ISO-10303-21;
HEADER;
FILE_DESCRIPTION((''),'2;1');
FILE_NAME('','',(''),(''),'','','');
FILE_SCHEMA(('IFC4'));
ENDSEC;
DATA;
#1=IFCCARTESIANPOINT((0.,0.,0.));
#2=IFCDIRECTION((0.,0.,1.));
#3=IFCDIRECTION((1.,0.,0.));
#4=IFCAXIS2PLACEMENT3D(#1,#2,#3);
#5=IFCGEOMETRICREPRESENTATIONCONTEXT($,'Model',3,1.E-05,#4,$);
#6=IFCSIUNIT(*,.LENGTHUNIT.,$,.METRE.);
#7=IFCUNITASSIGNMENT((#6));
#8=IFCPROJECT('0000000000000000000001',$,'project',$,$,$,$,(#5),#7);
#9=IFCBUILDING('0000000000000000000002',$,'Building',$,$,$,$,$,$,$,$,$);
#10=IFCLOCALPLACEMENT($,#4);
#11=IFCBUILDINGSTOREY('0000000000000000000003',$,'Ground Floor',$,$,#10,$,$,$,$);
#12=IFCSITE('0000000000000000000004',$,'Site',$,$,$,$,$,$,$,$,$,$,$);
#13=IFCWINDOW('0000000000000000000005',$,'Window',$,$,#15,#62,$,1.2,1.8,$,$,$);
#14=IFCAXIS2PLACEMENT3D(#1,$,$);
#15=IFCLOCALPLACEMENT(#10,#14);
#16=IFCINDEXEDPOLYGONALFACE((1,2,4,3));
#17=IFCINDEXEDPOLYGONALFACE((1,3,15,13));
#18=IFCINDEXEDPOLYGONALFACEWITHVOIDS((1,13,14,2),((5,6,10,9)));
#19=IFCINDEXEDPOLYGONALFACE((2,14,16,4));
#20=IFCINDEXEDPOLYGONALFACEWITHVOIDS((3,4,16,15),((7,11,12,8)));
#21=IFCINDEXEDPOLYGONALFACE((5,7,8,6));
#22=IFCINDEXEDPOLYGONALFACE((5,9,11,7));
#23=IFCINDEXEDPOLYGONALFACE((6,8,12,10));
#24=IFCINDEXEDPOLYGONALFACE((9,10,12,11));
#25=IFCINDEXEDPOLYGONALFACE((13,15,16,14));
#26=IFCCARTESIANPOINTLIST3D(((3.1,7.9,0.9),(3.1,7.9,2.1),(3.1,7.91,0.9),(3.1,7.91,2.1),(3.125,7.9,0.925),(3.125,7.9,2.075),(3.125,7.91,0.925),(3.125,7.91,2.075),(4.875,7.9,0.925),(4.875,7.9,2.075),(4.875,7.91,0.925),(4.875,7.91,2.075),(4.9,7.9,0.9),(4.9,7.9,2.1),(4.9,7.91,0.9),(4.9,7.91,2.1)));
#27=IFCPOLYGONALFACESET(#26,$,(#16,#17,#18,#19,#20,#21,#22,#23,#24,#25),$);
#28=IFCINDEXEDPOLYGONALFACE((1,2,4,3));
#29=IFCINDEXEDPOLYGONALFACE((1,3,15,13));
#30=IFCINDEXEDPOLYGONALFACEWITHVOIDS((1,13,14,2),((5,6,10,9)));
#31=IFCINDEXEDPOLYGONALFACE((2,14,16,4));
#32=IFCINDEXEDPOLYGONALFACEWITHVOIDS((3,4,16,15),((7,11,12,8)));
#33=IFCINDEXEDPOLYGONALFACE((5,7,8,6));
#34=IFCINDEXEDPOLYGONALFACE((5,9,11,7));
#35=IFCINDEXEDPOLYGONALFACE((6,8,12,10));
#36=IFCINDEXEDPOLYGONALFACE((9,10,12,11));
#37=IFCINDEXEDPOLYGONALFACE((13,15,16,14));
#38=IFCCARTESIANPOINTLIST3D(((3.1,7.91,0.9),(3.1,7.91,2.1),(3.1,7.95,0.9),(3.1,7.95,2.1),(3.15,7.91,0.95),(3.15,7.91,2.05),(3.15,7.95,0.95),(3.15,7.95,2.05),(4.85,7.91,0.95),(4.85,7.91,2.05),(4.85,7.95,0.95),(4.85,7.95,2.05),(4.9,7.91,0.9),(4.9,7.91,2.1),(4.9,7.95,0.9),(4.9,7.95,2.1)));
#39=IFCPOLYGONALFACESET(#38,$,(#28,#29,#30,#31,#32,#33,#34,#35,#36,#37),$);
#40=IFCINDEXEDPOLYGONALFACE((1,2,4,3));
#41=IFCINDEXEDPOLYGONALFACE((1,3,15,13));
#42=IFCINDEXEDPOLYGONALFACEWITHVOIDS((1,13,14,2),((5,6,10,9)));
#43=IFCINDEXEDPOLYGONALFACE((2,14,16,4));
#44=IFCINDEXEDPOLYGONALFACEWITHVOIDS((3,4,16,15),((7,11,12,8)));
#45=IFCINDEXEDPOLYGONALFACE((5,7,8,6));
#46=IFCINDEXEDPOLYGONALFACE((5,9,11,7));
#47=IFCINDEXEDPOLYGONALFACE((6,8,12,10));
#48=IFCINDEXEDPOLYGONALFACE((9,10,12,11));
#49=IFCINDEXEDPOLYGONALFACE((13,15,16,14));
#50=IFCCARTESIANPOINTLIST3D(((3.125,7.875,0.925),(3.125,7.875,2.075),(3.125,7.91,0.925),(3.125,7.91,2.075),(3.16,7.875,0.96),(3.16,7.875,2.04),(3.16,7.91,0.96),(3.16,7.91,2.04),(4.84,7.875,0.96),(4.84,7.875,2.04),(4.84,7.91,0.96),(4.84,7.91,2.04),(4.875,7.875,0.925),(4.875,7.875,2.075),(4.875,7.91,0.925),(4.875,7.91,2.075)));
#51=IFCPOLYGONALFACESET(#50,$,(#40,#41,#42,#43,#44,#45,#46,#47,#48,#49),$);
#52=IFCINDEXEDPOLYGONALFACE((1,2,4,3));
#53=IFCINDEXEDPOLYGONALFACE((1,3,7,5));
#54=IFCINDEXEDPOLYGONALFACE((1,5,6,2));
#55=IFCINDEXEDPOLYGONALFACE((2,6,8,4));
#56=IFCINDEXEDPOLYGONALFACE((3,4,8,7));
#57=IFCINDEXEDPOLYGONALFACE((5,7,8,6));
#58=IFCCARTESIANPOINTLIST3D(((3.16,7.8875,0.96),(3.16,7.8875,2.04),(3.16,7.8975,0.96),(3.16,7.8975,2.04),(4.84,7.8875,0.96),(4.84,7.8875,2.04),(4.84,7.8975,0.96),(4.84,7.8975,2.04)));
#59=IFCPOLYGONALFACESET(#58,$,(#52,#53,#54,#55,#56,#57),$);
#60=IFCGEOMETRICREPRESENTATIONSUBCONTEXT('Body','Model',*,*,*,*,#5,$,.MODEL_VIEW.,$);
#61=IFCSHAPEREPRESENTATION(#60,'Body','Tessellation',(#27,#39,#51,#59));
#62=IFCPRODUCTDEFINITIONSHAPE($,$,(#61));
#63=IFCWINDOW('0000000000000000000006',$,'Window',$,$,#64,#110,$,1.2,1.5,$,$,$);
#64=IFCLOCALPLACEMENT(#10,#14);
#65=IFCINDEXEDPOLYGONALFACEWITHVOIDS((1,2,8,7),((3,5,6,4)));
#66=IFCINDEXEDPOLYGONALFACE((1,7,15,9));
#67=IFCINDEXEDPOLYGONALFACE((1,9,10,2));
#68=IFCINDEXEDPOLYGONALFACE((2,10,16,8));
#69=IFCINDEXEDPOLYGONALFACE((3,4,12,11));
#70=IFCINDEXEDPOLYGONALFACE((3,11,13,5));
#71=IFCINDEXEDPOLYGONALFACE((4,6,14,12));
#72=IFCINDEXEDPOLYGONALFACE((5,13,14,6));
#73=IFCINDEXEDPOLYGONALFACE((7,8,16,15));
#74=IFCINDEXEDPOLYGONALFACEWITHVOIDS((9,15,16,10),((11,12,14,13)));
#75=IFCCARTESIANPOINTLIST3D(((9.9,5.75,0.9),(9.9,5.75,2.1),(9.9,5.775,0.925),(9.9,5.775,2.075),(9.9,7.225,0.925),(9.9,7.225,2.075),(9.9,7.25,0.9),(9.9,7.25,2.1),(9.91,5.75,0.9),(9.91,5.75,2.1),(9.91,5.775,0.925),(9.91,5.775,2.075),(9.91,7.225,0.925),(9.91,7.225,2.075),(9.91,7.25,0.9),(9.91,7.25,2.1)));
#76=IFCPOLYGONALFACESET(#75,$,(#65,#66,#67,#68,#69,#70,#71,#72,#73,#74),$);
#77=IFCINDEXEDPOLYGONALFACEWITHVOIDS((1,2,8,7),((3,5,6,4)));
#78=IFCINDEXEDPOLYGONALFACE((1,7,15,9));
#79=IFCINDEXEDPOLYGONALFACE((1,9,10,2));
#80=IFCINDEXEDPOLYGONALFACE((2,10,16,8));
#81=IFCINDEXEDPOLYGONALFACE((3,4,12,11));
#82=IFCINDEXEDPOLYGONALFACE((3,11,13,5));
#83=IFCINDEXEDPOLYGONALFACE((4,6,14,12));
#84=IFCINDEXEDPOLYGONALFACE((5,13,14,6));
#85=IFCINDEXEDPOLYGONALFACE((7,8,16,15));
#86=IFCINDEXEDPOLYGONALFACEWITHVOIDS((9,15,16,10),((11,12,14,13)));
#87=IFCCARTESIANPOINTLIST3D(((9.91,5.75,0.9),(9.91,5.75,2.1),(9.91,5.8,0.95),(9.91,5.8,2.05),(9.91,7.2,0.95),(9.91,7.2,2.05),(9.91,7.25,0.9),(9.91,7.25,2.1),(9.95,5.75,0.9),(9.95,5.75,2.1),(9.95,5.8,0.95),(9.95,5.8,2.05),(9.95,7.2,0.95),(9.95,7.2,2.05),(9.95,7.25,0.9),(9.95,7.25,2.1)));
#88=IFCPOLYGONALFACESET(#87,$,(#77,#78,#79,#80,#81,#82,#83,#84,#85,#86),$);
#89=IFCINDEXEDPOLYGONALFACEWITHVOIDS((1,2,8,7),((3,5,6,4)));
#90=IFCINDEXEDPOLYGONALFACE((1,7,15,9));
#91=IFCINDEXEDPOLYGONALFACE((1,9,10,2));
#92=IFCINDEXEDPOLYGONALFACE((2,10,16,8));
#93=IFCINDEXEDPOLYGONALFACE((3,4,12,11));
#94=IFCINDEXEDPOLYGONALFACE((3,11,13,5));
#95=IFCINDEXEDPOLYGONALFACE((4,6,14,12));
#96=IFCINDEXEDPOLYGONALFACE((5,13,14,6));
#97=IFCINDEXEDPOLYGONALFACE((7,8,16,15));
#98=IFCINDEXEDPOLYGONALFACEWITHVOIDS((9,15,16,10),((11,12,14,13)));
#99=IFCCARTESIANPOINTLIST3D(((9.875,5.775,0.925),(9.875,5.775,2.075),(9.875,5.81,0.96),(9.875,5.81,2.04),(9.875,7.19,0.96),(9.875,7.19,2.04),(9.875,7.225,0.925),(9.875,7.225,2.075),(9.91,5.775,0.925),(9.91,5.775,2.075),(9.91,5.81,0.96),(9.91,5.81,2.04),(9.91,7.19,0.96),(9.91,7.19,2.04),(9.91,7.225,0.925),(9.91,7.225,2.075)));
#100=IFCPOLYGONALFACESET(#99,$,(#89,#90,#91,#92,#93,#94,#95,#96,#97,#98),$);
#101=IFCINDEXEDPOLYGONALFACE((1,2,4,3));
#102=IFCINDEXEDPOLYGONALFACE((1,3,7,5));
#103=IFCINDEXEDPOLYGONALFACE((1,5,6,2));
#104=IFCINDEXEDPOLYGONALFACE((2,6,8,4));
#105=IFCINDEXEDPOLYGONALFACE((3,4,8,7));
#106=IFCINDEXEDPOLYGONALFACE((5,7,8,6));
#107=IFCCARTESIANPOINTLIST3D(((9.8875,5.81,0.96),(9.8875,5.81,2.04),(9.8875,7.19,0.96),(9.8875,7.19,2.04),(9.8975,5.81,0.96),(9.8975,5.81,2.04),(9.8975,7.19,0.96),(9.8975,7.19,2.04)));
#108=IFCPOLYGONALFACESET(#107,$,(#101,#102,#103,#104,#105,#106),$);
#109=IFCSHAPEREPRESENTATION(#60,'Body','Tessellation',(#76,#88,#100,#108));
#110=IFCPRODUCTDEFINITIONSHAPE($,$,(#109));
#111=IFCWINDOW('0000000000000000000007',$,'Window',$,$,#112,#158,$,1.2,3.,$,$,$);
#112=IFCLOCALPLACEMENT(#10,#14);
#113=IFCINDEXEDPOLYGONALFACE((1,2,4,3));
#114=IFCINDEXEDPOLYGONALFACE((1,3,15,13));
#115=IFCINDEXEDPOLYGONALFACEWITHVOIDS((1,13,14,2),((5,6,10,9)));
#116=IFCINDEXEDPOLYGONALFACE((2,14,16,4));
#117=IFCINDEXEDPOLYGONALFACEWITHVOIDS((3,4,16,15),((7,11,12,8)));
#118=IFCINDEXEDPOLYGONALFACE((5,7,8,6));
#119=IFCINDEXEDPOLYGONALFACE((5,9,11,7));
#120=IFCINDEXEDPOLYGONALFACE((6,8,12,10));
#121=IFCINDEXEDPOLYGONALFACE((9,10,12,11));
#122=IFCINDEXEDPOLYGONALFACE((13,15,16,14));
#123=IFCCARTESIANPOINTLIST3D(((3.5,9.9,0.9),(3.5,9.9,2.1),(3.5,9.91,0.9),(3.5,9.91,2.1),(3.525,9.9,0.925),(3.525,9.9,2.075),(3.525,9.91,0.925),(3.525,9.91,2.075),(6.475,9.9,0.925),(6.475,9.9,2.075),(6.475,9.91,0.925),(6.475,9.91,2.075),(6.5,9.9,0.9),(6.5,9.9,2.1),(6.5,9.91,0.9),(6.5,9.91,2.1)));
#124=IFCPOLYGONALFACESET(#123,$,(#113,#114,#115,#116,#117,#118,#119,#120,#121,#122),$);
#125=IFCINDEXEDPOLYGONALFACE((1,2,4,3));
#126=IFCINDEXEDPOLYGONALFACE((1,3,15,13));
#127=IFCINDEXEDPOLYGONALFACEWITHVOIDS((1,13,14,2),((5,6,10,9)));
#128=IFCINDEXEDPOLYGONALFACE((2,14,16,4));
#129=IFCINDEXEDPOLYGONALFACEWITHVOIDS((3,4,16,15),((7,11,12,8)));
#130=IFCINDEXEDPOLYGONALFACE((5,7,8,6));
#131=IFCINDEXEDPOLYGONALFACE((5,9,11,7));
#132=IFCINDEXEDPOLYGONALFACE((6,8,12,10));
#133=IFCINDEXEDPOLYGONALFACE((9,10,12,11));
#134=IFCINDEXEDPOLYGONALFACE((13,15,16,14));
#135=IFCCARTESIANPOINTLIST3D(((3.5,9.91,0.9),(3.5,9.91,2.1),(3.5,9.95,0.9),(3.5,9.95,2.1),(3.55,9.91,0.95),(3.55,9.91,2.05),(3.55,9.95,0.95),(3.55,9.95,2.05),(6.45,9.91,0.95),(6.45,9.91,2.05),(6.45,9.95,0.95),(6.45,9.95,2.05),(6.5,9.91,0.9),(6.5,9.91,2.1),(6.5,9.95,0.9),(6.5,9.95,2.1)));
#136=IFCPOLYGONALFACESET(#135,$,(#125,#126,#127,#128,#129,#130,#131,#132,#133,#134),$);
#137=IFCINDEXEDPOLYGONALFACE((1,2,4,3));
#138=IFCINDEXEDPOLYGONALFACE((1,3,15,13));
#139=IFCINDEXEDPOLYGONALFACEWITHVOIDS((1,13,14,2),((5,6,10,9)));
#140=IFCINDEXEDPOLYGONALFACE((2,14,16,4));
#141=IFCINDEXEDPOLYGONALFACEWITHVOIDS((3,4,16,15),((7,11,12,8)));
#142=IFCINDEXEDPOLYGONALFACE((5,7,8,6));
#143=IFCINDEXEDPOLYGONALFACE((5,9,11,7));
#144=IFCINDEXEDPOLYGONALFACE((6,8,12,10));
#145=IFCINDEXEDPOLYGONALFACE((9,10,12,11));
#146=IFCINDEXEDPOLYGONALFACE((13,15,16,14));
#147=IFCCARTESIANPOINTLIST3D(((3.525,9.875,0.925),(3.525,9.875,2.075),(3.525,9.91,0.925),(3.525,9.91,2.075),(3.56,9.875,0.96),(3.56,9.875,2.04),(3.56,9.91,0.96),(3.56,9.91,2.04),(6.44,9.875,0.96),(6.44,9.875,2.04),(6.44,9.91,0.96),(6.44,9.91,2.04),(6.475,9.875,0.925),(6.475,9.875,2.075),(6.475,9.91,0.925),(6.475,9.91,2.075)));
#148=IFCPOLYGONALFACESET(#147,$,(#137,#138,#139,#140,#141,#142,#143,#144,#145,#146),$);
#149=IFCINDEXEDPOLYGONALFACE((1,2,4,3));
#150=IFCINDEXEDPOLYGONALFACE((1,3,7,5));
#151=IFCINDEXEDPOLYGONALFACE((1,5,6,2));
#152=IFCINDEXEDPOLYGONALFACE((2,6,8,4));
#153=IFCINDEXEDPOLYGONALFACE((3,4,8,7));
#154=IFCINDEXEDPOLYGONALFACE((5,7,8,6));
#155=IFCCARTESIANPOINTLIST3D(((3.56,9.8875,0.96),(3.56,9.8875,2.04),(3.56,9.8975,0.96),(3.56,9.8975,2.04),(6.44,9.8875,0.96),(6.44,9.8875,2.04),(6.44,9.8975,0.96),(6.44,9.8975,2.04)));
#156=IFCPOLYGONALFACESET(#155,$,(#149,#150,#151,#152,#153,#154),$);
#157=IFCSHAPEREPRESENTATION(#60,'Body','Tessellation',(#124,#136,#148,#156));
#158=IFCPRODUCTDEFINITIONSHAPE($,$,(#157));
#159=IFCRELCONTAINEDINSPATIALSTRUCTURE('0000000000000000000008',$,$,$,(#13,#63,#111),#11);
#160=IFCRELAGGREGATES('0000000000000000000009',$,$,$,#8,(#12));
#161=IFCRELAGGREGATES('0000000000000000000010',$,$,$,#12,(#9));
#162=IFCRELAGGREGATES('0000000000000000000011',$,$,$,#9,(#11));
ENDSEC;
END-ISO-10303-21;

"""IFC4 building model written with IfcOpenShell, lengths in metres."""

from ifc_helpers import new_model, si_unit, frame, origin_with_axes, place, context, subcontext, project, spatial, line, indexed_curve, outline, extrude, element, save


model = new_model("IFC4")

# Units and contexts
model_context = context("Model", 3, precision=1e-05, world=origin_with_axes())
body_context = subcontext(model_context, "Body", "Model", "MODEL_VIEW")
ifc_project = project(units=[si_unit("LENGTHUNIT", "METRE")], contexts=[model_context])

# Site, building, storey
site = spatial("IfcSite", under=ifc_project, Name="Site")
building = spatial("IfcBuilding", under=site, Name="Building")
storey_placement = place(None, origin_with_axes())
storey = spatial("IfcBuildingStorey", under=building, at=storey_placement, Name="Ground Floor")

# Windows
window_1_placement = place(storey_placement, frame((4.9, 8.0, 0.9), z_axis=(0.0, 0.0, 1.0), x_axis=(-1.0, 0.0, 0.0)))
element("IfcWindow", 1, at=window_1_placement, inside=storey, Name="Window", OverallHeight=1.2, OverallWidth=1.8, context=body_context, shape_type="SweptSolid", body=[
    extrude(outline(indexed_curve([(0.0, 0.0), (1.8, 0.0), (1.8, 1.2), (0.0, 1.2)], segments=[line(1, 2, 3, 4, 1)]), holes=[indexed_curve([(0.025, 0.025), (1.775, 0.025), (1.775, 1.175), (0.025, 1.175)], segments=[line(1, 2, 3, 4, 1)])]), frame((0.0, 0.09, 0.0), z_axis=(0.0, -1.0, 0.0), x_axis=(1.0, 0.0, 0.0)), (0.0, 0.0, -1.0), 0.01),
    extrude(outline(indexed_curve([(0.0, 0.0), (1.8, 0.0), (1.8, 1.2), (0.0, 1.2)], segments=[line(1, 2, 3, 4, 1)]), holes=[indexed_curve([(0.05, 0.05), (1.75, 0.05), (1.75, 1.15), (0.05, 1.15)], segments=[line(1, 2, 3, 4, 1)])]), frame((0.0, 0.05, 0.0), z_axis=(0.0, -1.0, 0.0), x_axis=(1.0, 0.0, 0.0)), (0.0, 0.0, -1.0), 0.04),
    extrude(outline(indexed_curve([(0.0, 0.0), (1.75, 0.0), (1.75, 1.15), (0.0, 1.15)], segments=[line(1, 2, 3, 4, 1)]), holes=[indexed_curve([(0.035, 0.035), (1.715, 0.035), (1.715, 1.115), (0.035, 1.115)], segments=[line(1, 2, 3, 4, 1)])]), frame((0.025, 0.09, 0.025), z_axis=(0.0, -1.0, 0.0), x_axis=(1.0, 0.0, 0.0)), (0.0, 0.0, -1.0), 0.035),
    extrude(outline(indexed_curve([(0.035, 0.035), (1.715, 0.035), (1.715, 1.115), (0.035, 1.115)], segments=[line(1, 2, 3, 4, 1)])), frame((0.025, 0.1025, 0.025), z_axis=(0.0, -1.0, 0.0), x_axis=(1.0, 0.0, 0.0)), (0.0, 0.0, -1.0), 0.01),
])
window_2_placement = place(storey_placement, frame((10.0, 5.75, 0.9), z_axis=(0.0, 0.0, 1.0), x_axis=(0.0, 1.0, 0.0)))
element("IfcWindow", 2, at=window_2_placement, inside=storey, Name="Window", OverallHeight=1.2, OverallWidth=1.5, context=body_context, shape_type="SweptSolid", body=[
    extrude(outline(indexed_curve([(0.0, 0.0), (1.5, 0.0), (1.5, 1.2), (0.0, 1.2)], segments=[line(1, 2, 3, 4, 1)]), holes=[indexed_curve([(0.025, 0.025), (1.475, 0.025), (1.475, 1.175), (0.025, 1.175)], segments=[line(1, 2, 3, 4, 1)])]), frame((0.0, 0.09, 0.0), z_axis=(0.0, -1.0, 0.0), x_axis=(1.0, 0.0, 0.0)), (0.0, 0.0, -1.0), 0.01),
    extrude(outline(indexed_curve([(0.0, 0.0), (1.5, 0.0), (1.5, 1.2), (0.0, 1.2)], segments=[line(1, 2, 3, 4, 1)]), holes=[indexed_curve([(0.05, 0.05), (1.45, 0.05), (1.45, 1.15), (0.05, 1.15)], segments=[line(1, 2, 3, 4, 1)])]), frame((0.0, 0.05, 0.0), z_axis=(0.0, -1.0, 0.0), x_axis=(1.0, 0.0, 0.0)), (0.0, 0.0, -1.0), 0.04),
    extrude(outline(indexed_curve([(0.0, 0.0), (1.45, 0.0), (1.45, 1.15), (0.0, 1.15)], segments=[line(1, 2, 3, 4, 1)]), holes=[indexed_curve([(0.035, 0.035), (1.415, 0.035), (1.415, 1.115), (0.035, 1.115)], segments=[line(1, 2, 3, 4, 1)])]), frame((0.025, 0.09, 0.025), z_axis=(0.0, -1.0, 0.0), x_axis=(1.0, 0.0, 0.0)), (0.0, 0.0, -1.0), 0.035),
    extrude(outline(indexed_curve([(0.035, 0.035), (1.415, 0.035), (1.415, 1.115), (0.035, 1.115)], segments=[line(1, 2, 3, 4, 1)])), frame((0.025, 0.1025, 0.025), z_axis=(0.0, -1.0, 0.0), x_axis=(1.0, 0.0, 0.0)), (0.0, 0.0, -1.0), 0.01),
])
window_3_placement = place(storey_placement, frame((6.5, 10.0, 0.9), z_axis=(0.0, 0.0, 1.0), x_axis=(-1.0, 0.0, 0.0)))
element("IfcWindow", 3, at=window_3_placement, inside=storey, Name="Window", OverallHeight=1.2, OverallWidth=3.0, context=body_context, shape_type="SweptSolid", body=[
    extrude(outline(indexed_curve([(0.0, 0.0), (3.0, 0.0), (3.0, 1.2), (0.0, 1.2)], segments=[line(1, 2, 3, 4, 1)]), holes=[indexed_curve([(0.025, 0.025), (2.975, 0.025), (2.975, 1.175), (0.025, 1.175)], segments=[line(1, 2, 3, 4, 1)])]), frame((0.0, 0.09, 0.0), z_axis=(0.0, -1.0, 0.0), x_axis=(1.0, 0.0, 0.0)), (0.0, 0.0, -1.0), 0.01),
    extrude(outline(indexed_curve([(0.0, 0.0), (3.0, 0.0), (3.0, 1.2), (0.0, 1.2)], segments=[line(1, 2, 3, 4, 1)]), holes=[indexed_curve([(0.05, 0.05), (2.95, 0.05), (2.95, 1.15), (0.05, 1.15)], segments=[line(1, 2, 3, 4, 1)])]), frame((0.0, 0.05, 0.0), z_axis=(0.0, -1.0, 0.0), x_axis=(1.0, 0.0, 0.0)), (0.0, 0.0, -1.0), 0.04),
    extrude(outline(indexed_curve([(0.0, 0.0), (2.95, 0.0), (2.95, 1.15), (0.0, 1.15)], segments=[line(1, 2, 3, 4, 1)]), holes=[indexed_curve([(0.035, 0.035), (2.915, 0.035), (2.915, 1.115), (0.035, 1.115)], segments=[line(1, 2, 3, 4, 1)])]), frame((0.025, 0.09, 0.025), z_axis=(0.0, -1.0, 0.0), x_axis=(1.0, 0.0, 0.0)), (0.0, 0.0, -1.0), 0.035),
    extrude(outline(indexed_curve([(0.035, 0.035), (2.915, 0.035), (2.915, 1.115), (0.035, 1.115)], segments=[line(1, 2, 3, 4, 1)])), frame((0.025, 0.1025, 0.025), z_axis=(0.0, -1.0, 0.0), x_axis=(1.0, 0.0, 0.0)), (0.0, 0.0, -1.0), 0.01),
])

save(model, "model.ifc")
